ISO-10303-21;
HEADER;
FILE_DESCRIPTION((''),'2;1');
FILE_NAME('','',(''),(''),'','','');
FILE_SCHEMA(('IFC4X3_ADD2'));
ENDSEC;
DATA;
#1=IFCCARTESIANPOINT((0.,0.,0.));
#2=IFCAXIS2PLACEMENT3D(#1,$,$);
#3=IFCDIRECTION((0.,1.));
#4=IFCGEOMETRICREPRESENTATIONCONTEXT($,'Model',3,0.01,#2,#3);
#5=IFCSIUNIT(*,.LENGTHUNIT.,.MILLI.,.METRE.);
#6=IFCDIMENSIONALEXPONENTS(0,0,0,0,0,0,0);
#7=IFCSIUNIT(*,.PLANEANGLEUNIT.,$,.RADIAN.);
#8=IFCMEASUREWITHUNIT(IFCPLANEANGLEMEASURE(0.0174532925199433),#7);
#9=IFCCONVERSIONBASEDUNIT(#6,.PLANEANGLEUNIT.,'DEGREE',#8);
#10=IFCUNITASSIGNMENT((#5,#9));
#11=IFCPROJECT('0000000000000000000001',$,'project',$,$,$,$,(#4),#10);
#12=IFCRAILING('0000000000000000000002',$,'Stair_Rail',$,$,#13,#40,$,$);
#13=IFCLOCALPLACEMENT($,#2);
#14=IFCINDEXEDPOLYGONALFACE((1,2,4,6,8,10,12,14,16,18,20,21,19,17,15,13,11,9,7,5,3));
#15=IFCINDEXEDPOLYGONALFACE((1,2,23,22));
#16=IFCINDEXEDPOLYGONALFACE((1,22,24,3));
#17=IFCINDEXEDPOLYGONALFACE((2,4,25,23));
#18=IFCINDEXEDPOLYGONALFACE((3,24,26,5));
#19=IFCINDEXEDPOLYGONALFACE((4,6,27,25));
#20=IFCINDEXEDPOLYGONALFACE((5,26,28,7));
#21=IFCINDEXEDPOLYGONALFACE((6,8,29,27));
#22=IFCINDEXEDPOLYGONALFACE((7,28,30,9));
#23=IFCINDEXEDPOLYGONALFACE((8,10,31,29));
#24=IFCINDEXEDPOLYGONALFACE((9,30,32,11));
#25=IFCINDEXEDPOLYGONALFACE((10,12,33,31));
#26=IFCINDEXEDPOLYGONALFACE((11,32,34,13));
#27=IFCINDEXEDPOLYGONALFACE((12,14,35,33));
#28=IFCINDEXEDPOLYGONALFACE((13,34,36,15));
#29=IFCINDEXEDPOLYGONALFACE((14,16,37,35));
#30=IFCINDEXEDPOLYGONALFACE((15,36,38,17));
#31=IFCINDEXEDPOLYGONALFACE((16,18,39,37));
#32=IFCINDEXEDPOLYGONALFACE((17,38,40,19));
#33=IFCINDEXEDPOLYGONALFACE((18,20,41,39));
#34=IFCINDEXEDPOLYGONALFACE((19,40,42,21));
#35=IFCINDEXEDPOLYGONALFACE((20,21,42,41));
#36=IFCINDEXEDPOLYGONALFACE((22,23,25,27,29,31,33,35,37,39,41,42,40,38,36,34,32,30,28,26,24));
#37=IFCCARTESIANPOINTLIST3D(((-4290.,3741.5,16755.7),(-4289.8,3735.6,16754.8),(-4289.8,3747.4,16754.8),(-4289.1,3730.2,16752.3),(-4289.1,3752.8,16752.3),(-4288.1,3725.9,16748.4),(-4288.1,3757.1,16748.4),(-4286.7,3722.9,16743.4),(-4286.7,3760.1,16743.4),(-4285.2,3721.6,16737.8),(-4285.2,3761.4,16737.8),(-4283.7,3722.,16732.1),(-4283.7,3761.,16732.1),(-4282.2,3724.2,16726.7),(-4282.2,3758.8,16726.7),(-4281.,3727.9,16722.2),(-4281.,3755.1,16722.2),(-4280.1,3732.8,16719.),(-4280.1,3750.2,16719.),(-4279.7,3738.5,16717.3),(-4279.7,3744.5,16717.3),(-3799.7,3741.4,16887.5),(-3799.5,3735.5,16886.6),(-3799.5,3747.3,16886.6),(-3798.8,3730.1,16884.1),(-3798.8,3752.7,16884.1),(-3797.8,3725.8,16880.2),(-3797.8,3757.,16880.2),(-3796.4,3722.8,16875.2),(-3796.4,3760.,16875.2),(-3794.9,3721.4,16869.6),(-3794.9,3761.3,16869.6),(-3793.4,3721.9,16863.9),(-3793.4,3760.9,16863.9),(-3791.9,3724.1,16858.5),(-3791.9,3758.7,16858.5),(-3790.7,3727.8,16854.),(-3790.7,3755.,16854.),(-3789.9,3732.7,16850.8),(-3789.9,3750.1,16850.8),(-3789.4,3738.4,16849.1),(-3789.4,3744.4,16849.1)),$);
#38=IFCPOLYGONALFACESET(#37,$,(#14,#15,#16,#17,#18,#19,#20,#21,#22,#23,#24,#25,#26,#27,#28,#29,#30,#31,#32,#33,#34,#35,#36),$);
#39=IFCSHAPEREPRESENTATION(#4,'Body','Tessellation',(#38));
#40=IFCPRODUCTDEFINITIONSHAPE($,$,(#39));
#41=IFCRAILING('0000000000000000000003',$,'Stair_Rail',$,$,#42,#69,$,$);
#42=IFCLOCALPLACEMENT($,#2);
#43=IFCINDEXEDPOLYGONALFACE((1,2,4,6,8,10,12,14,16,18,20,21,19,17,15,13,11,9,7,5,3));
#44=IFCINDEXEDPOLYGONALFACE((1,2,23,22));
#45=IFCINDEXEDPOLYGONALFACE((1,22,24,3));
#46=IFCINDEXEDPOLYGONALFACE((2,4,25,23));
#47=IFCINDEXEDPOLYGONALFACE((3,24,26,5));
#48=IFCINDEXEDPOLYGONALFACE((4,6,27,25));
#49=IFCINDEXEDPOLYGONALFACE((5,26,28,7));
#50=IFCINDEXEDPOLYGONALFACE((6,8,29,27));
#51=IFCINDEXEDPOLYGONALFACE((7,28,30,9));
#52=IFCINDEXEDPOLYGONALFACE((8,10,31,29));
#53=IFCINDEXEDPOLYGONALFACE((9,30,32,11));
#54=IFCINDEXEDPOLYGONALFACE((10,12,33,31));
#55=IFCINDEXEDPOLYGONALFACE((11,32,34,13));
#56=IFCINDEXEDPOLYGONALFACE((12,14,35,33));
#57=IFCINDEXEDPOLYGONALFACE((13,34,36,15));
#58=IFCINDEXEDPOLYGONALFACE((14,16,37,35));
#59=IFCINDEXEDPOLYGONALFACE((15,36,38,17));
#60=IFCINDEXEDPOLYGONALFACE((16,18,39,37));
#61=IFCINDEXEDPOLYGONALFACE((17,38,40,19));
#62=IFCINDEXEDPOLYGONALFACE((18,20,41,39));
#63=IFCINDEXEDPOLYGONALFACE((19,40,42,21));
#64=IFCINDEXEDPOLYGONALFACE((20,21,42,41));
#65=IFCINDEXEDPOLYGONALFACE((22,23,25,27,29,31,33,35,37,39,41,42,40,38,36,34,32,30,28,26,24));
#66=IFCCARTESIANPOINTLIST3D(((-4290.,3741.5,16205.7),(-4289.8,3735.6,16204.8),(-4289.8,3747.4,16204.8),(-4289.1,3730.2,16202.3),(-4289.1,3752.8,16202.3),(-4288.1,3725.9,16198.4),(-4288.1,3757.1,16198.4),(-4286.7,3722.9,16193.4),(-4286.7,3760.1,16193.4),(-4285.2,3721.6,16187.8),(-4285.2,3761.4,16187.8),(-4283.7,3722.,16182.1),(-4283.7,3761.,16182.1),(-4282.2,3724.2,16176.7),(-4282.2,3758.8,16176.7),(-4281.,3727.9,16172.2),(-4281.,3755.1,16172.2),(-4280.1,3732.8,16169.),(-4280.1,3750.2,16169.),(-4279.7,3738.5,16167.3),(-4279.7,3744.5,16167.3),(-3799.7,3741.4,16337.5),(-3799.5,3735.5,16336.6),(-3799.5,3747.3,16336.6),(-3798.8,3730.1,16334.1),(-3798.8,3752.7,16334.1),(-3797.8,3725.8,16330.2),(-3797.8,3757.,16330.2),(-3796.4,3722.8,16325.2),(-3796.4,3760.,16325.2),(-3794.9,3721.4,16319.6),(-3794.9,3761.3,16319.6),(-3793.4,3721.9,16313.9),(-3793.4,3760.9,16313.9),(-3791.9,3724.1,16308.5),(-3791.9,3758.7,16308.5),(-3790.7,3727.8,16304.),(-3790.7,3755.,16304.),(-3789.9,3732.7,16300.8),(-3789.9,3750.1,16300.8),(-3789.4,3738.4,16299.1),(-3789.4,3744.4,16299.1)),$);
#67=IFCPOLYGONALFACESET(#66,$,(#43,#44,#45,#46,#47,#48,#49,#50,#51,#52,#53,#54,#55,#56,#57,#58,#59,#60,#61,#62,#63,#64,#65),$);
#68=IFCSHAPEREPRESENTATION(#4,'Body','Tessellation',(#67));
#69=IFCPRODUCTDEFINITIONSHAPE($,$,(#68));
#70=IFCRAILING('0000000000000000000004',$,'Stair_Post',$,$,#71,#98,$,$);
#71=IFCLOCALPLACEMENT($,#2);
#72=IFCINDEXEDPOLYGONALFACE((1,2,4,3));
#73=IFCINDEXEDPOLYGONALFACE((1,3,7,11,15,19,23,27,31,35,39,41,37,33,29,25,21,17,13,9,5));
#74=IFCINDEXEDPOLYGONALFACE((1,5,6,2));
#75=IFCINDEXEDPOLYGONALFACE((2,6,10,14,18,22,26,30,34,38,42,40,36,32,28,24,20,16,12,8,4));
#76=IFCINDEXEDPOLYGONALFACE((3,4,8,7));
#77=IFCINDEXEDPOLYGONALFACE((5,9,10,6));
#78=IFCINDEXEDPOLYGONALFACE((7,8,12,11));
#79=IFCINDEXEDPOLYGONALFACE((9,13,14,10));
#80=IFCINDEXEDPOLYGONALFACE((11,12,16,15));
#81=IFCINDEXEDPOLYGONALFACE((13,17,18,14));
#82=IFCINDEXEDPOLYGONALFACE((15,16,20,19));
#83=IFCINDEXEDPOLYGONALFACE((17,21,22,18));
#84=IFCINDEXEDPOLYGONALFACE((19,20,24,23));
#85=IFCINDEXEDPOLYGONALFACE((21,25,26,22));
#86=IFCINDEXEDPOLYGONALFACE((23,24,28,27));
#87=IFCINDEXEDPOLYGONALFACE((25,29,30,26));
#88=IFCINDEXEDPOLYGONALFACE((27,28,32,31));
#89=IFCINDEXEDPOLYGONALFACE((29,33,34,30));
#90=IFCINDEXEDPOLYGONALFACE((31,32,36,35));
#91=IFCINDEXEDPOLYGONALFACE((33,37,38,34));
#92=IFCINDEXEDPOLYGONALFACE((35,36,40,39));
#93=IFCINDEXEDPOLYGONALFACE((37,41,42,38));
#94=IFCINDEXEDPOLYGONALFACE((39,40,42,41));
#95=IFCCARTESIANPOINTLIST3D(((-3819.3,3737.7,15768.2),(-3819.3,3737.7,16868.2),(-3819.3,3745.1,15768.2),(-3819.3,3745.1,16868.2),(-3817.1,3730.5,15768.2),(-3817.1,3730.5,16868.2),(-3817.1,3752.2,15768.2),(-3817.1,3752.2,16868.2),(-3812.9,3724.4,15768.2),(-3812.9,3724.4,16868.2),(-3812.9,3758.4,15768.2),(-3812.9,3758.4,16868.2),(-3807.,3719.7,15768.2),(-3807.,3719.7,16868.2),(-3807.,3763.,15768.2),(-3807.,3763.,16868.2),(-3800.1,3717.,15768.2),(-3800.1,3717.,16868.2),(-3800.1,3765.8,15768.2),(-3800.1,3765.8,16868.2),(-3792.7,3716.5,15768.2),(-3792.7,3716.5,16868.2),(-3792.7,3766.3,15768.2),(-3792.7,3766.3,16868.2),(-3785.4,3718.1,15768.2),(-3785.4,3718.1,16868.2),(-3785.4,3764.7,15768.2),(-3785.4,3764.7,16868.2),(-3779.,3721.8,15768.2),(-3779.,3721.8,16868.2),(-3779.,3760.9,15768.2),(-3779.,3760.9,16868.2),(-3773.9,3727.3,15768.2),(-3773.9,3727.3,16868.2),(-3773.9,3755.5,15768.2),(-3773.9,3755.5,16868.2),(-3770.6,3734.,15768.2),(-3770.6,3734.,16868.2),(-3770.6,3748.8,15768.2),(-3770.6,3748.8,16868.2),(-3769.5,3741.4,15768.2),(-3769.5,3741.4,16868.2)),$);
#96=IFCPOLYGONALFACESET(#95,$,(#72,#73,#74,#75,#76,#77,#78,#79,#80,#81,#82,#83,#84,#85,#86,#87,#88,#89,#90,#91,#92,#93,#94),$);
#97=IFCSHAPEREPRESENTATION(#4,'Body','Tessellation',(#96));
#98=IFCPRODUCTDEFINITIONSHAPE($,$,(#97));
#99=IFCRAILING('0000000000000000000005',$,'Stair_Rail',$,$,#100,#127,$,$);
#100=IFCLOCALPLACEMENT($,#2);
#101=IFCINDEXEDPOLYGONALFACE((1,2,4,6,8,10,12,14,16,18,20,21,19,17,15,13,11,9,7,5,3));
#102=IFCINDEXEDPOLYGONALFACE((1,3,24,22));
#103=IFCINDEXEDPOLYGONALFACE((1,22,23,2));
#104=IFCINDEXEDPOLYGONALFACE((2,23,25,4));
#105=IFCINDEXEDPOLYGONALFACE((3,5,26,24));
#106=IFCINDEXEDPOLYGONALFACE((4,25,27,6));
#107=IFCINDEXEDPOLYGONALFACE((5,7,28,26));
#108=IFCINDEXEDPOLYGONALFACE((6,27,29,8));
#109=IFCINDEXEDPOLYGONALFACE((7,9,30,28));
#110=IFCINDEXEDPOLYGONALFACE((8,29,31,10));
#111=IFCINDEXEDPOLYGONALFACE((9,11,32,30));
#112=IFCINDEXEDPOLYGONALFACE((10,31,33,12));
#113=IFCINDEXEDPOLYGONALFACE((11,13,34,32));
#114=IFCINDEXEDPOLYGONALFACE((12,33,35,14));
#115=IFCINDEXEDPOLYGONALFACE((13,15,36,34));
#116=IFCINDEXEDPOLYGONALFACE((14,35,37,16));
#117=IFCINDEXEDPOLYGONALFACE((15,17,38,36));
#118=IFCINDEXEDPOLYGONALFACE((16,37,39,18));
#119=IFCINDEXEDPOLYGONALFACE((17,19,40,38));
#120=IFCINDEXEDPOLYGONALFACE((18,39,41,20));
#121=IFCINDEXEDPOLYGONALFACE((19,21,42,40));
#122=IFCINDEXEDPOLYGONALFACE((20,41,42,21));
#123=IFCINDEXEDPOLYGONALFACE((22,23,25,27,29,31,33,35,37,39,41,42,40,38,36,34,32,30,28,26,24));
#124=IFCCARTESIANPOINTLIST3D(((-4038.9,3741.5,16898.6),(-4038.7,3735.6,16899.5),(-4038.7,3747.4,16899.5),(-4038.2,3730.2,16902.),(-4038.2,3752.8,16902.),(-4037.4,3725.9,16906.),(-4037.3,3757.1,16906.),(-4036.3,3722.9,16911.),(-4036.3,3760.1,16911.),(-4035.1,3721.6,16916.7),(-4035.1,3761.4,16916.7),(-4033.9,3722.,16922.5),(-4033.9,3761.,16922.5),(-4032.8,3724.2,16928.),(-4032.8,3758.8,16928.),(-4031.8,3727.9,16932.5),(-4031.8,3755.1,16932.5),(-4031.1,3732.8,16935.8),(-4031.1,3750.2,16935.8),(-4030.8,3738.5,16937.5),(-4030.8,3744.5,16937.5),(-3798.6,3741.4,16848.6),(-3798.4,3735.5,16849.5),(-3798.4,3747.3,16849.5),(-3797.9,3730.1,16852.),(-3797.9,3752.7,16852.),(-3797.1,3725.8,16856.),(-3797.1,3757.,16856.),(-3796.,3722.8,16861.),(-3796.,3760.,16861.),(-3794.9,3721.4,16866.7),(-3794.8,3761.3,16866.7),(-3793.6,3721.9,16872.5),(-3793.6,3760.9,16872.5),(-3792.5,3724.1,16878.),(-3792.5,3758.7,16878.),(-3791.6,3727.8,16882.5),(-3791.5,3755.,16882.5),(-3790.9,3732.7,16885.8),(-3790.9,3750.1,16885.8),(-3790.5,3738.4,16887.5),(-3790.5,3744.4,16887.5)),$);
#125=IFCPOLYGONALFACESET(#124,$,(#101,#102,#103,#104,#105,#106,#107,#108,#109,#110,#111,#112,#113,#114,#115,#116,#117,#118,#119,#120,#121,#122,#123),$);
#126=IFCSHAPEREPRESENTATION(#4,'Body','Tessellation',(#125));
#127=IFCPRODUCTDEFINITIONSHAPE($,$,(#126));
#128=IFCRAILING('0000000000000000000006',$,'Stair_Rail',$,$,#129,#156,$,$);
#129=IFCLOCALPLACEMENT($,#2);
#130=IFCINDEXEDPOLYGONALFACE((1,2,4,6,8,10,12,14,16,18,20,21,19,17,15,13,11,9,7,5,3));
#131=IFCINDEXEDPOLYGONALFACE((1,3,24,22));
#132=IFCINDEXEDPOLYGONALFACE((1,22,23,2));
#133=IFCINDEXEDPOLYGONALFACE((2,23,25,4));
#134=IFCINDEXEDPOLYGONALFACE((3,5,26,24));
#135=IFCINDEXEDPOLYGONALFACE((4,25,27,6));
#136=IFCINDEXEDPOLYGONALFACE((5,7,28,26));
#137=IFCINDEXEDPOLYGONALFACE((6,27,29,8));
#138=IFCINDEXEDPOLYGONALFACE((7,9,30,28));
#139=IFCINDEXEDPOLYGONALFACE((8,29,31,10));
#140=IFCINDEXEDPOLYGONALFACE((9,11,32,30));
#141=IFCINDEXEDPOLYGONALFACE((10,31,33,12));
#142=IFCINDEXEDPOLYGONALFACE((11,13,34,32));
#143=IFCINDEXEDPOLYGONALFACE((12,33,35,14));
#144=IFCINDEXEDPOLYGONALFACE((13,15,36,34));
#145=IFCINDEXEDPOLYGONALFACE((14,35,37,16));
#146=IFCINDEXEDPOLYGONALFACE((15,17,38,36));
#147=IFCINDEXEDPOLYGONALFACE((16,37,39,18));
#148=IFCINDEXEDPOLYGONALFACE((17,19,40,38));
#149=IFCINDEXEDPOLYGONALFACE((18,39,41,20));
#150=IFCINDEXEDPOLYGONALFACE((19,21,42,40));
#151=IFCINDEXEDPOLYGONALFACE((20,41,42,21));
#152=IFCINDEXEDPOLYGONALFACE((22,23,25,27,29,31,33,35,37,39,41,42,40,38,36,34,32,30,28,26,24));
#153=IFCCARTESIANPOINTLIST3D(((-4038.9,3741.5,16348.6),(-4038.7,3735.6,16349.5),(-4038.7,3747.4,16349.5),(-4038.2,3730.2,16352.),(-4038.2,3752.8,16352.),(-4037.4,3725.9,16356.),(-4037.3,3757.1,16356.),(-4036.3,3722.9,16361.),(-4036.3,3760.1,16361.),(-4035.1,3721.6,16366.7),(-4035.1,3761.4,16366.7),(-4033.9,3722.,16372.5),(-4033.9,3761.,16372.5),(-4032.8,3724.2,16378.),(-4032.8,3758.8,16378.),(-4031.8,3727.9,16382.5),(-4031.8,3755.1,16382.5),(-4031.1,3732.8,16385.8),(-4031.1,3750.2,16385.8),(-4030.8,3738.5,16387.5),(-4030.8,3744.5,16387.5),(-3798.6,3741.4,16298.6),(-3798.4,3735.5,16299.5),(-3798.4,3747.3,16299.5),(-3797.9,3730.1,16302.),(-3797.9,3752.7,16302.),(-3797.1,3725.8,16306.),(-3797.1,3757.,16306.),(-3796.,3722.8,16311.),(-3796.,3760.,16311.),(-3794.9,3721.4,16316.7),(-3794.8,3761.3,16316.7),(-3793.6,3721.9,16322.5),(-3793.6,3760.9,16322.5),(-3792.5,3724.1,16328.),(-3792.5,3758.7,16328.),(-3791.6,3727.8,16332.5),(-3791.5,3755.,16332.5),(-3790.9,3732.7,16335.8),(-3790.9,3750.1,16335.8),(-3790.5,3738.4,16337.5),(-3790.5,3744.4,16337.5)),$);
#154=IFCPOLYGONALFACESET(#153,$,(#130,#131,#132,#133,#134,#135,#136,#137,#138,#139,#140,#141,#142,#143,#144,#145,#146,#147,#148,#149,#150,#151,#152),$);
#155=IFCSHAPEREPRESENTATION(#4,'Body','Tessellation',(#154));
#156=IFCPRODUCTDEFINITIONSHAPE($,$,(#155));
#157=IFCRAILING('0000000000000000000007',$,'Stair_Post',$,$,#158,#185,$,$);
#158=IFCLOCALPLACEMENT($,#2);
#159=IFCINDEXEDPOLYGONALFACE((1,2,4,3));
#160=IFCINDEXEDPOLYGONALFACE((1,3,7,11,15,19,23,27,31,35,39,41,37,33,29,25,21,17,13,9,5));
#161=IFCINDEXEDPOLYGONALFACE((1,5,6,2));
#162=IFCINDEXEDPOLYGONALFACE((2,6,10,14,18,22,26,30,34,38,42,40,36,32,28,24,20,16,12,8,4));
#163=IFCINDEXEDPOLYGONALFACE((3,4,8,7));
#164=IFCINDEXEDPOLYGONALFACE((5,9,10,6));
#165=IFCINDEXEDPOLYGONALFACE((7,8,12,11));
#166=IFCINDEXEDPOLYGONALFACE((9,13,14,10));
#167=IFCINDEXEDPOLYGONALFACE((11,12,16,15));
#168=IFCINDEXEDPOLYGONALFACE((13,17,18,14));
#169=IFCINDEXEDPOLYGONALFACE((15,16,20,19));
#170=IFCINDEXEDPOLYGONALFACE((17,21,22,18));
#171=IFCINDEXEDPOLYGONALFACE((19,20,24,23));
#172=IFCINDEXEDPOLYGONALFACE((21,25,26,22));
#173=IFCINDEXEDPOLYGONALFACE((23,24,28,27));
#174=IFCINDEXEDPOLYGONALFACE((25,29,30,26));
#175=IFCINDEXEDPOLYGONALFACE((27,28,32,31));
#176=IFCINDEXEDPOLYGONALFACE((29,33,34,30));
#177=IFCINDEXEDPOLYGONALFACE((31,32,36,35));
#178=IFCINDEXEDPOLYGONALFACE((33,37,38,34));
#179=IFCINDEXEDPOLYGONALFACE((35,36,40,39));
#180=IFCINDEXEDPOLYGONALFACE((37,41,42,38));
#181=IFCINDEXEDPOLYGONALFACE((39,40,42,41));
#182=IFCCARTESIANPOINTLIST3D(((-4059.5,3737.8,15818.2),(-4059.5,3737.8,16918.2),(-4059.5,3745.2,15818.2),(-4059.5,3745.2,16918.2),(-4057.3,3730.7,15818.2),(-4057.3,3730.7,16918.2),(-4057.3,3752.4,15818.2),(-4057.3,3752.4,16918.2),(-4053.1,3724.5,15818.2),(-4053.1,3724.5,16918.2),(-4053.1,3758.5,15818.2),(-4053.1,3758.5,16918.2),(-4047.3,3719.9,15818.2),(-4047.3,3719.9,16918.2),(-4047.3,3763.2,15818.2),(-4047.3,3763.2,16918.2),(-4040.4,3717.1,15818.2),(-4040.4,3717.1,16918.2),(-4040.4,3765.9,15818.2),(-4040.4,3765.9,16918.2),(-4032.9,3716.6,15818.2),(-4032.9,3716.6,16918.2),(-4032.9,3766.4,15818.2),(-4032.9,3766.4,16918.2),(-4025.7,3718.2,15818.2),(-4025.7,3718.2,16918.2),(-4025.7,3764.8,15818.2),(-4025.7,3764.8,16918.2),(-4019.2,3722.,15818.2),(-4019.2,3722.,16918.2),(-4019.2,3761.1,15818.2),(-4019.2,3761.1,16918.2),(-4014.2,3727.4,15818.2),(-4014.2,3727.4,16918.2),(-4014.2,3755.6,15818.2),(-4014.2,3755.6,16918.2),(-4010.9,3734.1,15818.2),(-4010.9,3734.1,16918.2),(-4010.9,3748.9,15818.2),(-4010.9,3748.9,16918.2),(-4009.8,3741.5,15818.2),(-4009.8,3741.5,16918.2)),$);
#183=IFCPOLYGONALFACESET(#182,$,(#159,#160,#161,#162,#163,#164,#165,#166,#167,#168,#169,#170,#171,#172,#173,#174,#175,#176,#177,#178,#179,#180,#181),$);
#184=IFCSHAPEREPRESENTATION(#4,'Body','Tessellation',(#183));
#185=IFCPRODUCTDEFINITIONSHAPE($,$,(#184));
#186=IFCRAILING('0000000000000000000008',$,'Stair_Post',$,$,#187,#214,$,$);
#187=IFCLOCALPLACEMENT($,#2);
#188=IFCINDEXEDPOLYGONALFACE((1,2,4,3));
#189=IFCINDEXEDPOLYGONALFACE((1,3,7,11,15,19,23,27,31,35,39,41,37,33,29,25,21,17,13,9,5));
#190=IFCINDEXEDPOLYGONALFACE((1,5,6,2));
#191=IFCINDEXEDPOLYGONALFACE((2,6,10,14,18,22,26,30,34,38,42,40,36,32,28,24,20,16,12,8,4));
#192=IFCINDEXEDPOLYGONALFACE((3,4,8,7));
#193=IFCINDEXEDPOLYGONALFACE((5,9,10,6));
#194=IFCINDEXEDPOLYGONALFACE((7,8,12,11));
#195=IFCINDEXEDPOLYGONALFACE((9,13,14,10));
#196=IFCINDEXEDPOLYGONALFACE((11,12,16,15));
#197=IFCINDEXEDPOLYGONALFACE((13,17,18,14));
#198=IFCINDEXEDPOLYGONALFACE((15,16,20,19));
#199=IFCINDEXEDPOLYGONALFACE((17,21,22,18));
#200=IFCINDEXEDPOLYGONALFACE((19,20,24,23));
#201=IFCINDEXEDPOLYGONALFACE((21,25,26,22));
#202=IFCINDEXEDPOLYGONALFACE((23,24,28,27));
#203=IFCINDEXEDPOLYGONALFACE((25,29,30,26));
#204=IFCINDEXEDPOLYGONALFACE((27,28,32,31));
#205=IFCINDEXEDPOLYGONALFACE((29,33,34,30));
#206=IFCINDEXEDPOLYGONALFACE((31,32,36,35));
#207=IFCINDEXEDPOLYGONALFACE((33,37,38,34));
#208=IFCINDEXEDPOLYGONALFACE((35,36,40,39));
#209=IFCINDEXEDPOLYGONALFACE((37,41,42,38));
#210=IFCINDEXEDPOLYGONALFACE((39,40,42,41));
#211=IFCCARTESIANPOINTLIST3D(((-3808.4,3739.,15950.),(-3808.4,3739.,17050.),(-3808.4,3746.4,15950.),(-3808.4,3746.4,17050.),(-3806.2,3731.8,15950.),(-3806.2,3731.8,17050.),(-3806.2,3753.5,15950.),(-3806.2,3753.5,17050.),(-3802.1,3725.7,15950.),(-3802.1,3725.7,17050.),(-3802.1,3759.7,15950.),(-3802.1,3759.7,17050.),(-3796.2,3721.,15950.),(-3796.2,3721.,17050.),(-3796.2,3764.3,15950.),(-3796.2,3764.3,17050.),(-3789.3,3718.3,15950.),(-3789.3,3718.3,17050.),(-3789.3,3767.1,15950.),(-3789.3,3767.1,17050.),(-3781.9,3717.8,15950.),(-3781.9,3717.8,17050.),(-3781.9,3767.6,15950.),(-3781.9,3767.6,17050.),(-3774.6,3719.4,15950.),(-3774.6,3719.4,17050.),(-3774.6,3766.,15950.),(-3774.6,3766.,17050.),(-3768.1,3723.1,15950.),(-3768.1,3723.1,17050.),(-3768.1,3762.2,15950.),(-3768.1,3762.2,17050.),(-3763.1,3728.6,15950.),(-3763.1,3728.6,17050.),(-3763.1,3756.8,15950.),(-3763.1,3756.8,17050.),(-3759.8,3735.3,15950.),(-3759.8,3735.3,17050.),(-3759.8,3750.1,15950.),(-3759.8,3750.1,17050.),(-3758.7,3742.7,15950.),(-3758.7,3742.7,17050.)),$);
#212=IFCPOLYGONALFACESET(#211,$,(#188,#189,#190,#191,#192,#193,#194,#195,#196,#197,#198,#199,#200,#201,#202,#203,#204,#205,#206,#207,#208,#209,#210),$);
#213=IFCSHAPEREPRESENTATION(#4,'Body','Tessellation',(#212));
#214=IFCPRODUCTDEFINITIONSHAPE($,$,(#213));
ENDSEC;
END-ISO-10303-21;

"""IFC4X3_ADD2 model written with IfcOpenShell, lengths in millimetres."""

from ifc_helpers import new_model, entity, si_unit, converted_unit, direction, frame, origin, context, project, circle, extrude, element, save


model = new_model("IFC4X3_ADD2")

# Units and contexts
model_context = context("Model", 3, precision=0.01, world=origin(), true_north=direction((0.0, 1.0)))
ifc_project = project(units=[si_unit("LENGTHUNIT", "METRE", prefix="MILLI"), converted_unit("PLANEANGLEUNIT", "DEGREE", entity("IfcPlaneAngleMeasure", 0.0174532925199433), si_unit("PLANEANGLEUNIT", "RADIAN"), dimensions=[0, 0, 0, 0, 0, 0, 0])], contexts=[model_context])

# Railings
element("IfcRailing", 1, Name="Stair_Rail", context=model_context, shape_type="SweptSolid", body=[
    entity("IfcSweptDiskSolid", entity("IfcPolyline", [entity("IfcCartesianPoint", [-4284.8, 3741.5, 16736.4]), entity("IfcCartesianPoint", [-3794.5, 3741.4, 16868.2])]), 20.0),
])
element("IfcRailing", 2, Name="Stair_Rail", context=model_context, shape_type="SweptSolid", body=[
    entity("IfcSweptDiskSolid", entity("IfcPolyline", [entity("IfcCartesianPoint", [-4284.8, 3741.5, 16186.4]), entity("IfcCartesianPoint", [-3794.5, 3741.4, 16318.2])]), 20.0),
])
element("IfcRailing", 3, Name="Stair_Post", context=model_context, shape_type="SweptSolid", body=[
    extrude(circle(Radius=25.0), frame((-3794.5, 3741.4, 15768.2)), (0.0, 0.0, 1.0), 1100.0),
])
element("IfcRailing", 4, Name="Stair_Rail", context=model_context, shape_type="SweptSolid", body=[
    entity("IfcSweptDiskSolid", entity("IfcPolyline", [entity("IfcCartesianPoint", [-3794.5, 3741.4, 16868.2]), entity("IfcCartesianPoint", [-4034.8, 3741.5, 16918.2])]), 20.0),
])
element("IfcRailing", 5, Name="Stair_Rail", context=model_context, shape_type="SweptSolid", body=[
    entity("IfcSweptDiskSolid", entity("IfcPolyline", [entity("IfcCartesianPoint", [-3794.5, 3741.4, 16318.2]), entity("IfcCartesianPoint", [-4034.8, 3741.5, 16368.2])]), 20.0),
])
element("IfcRailing", 6, Name="Stair_Post", context=model_context, shape_type="SweptSolid", body=[
    extrude(circle(Radius=25.0), frame((-4034.8, 3741.5, 15818.2)), (0.0, 0.0, 1.0), 1100.0),
])
element("IfcRailing", 7, Name="Stair_Post", context=model_context, shape_type="SweptSolid", body=[
    extrude(circle(Radius=25.0), frame((-3783.7, 3742.7, 15950.0)), (0.0, 0.0, 1.0), 1100.0),
])

save(model, "model.ifc")
